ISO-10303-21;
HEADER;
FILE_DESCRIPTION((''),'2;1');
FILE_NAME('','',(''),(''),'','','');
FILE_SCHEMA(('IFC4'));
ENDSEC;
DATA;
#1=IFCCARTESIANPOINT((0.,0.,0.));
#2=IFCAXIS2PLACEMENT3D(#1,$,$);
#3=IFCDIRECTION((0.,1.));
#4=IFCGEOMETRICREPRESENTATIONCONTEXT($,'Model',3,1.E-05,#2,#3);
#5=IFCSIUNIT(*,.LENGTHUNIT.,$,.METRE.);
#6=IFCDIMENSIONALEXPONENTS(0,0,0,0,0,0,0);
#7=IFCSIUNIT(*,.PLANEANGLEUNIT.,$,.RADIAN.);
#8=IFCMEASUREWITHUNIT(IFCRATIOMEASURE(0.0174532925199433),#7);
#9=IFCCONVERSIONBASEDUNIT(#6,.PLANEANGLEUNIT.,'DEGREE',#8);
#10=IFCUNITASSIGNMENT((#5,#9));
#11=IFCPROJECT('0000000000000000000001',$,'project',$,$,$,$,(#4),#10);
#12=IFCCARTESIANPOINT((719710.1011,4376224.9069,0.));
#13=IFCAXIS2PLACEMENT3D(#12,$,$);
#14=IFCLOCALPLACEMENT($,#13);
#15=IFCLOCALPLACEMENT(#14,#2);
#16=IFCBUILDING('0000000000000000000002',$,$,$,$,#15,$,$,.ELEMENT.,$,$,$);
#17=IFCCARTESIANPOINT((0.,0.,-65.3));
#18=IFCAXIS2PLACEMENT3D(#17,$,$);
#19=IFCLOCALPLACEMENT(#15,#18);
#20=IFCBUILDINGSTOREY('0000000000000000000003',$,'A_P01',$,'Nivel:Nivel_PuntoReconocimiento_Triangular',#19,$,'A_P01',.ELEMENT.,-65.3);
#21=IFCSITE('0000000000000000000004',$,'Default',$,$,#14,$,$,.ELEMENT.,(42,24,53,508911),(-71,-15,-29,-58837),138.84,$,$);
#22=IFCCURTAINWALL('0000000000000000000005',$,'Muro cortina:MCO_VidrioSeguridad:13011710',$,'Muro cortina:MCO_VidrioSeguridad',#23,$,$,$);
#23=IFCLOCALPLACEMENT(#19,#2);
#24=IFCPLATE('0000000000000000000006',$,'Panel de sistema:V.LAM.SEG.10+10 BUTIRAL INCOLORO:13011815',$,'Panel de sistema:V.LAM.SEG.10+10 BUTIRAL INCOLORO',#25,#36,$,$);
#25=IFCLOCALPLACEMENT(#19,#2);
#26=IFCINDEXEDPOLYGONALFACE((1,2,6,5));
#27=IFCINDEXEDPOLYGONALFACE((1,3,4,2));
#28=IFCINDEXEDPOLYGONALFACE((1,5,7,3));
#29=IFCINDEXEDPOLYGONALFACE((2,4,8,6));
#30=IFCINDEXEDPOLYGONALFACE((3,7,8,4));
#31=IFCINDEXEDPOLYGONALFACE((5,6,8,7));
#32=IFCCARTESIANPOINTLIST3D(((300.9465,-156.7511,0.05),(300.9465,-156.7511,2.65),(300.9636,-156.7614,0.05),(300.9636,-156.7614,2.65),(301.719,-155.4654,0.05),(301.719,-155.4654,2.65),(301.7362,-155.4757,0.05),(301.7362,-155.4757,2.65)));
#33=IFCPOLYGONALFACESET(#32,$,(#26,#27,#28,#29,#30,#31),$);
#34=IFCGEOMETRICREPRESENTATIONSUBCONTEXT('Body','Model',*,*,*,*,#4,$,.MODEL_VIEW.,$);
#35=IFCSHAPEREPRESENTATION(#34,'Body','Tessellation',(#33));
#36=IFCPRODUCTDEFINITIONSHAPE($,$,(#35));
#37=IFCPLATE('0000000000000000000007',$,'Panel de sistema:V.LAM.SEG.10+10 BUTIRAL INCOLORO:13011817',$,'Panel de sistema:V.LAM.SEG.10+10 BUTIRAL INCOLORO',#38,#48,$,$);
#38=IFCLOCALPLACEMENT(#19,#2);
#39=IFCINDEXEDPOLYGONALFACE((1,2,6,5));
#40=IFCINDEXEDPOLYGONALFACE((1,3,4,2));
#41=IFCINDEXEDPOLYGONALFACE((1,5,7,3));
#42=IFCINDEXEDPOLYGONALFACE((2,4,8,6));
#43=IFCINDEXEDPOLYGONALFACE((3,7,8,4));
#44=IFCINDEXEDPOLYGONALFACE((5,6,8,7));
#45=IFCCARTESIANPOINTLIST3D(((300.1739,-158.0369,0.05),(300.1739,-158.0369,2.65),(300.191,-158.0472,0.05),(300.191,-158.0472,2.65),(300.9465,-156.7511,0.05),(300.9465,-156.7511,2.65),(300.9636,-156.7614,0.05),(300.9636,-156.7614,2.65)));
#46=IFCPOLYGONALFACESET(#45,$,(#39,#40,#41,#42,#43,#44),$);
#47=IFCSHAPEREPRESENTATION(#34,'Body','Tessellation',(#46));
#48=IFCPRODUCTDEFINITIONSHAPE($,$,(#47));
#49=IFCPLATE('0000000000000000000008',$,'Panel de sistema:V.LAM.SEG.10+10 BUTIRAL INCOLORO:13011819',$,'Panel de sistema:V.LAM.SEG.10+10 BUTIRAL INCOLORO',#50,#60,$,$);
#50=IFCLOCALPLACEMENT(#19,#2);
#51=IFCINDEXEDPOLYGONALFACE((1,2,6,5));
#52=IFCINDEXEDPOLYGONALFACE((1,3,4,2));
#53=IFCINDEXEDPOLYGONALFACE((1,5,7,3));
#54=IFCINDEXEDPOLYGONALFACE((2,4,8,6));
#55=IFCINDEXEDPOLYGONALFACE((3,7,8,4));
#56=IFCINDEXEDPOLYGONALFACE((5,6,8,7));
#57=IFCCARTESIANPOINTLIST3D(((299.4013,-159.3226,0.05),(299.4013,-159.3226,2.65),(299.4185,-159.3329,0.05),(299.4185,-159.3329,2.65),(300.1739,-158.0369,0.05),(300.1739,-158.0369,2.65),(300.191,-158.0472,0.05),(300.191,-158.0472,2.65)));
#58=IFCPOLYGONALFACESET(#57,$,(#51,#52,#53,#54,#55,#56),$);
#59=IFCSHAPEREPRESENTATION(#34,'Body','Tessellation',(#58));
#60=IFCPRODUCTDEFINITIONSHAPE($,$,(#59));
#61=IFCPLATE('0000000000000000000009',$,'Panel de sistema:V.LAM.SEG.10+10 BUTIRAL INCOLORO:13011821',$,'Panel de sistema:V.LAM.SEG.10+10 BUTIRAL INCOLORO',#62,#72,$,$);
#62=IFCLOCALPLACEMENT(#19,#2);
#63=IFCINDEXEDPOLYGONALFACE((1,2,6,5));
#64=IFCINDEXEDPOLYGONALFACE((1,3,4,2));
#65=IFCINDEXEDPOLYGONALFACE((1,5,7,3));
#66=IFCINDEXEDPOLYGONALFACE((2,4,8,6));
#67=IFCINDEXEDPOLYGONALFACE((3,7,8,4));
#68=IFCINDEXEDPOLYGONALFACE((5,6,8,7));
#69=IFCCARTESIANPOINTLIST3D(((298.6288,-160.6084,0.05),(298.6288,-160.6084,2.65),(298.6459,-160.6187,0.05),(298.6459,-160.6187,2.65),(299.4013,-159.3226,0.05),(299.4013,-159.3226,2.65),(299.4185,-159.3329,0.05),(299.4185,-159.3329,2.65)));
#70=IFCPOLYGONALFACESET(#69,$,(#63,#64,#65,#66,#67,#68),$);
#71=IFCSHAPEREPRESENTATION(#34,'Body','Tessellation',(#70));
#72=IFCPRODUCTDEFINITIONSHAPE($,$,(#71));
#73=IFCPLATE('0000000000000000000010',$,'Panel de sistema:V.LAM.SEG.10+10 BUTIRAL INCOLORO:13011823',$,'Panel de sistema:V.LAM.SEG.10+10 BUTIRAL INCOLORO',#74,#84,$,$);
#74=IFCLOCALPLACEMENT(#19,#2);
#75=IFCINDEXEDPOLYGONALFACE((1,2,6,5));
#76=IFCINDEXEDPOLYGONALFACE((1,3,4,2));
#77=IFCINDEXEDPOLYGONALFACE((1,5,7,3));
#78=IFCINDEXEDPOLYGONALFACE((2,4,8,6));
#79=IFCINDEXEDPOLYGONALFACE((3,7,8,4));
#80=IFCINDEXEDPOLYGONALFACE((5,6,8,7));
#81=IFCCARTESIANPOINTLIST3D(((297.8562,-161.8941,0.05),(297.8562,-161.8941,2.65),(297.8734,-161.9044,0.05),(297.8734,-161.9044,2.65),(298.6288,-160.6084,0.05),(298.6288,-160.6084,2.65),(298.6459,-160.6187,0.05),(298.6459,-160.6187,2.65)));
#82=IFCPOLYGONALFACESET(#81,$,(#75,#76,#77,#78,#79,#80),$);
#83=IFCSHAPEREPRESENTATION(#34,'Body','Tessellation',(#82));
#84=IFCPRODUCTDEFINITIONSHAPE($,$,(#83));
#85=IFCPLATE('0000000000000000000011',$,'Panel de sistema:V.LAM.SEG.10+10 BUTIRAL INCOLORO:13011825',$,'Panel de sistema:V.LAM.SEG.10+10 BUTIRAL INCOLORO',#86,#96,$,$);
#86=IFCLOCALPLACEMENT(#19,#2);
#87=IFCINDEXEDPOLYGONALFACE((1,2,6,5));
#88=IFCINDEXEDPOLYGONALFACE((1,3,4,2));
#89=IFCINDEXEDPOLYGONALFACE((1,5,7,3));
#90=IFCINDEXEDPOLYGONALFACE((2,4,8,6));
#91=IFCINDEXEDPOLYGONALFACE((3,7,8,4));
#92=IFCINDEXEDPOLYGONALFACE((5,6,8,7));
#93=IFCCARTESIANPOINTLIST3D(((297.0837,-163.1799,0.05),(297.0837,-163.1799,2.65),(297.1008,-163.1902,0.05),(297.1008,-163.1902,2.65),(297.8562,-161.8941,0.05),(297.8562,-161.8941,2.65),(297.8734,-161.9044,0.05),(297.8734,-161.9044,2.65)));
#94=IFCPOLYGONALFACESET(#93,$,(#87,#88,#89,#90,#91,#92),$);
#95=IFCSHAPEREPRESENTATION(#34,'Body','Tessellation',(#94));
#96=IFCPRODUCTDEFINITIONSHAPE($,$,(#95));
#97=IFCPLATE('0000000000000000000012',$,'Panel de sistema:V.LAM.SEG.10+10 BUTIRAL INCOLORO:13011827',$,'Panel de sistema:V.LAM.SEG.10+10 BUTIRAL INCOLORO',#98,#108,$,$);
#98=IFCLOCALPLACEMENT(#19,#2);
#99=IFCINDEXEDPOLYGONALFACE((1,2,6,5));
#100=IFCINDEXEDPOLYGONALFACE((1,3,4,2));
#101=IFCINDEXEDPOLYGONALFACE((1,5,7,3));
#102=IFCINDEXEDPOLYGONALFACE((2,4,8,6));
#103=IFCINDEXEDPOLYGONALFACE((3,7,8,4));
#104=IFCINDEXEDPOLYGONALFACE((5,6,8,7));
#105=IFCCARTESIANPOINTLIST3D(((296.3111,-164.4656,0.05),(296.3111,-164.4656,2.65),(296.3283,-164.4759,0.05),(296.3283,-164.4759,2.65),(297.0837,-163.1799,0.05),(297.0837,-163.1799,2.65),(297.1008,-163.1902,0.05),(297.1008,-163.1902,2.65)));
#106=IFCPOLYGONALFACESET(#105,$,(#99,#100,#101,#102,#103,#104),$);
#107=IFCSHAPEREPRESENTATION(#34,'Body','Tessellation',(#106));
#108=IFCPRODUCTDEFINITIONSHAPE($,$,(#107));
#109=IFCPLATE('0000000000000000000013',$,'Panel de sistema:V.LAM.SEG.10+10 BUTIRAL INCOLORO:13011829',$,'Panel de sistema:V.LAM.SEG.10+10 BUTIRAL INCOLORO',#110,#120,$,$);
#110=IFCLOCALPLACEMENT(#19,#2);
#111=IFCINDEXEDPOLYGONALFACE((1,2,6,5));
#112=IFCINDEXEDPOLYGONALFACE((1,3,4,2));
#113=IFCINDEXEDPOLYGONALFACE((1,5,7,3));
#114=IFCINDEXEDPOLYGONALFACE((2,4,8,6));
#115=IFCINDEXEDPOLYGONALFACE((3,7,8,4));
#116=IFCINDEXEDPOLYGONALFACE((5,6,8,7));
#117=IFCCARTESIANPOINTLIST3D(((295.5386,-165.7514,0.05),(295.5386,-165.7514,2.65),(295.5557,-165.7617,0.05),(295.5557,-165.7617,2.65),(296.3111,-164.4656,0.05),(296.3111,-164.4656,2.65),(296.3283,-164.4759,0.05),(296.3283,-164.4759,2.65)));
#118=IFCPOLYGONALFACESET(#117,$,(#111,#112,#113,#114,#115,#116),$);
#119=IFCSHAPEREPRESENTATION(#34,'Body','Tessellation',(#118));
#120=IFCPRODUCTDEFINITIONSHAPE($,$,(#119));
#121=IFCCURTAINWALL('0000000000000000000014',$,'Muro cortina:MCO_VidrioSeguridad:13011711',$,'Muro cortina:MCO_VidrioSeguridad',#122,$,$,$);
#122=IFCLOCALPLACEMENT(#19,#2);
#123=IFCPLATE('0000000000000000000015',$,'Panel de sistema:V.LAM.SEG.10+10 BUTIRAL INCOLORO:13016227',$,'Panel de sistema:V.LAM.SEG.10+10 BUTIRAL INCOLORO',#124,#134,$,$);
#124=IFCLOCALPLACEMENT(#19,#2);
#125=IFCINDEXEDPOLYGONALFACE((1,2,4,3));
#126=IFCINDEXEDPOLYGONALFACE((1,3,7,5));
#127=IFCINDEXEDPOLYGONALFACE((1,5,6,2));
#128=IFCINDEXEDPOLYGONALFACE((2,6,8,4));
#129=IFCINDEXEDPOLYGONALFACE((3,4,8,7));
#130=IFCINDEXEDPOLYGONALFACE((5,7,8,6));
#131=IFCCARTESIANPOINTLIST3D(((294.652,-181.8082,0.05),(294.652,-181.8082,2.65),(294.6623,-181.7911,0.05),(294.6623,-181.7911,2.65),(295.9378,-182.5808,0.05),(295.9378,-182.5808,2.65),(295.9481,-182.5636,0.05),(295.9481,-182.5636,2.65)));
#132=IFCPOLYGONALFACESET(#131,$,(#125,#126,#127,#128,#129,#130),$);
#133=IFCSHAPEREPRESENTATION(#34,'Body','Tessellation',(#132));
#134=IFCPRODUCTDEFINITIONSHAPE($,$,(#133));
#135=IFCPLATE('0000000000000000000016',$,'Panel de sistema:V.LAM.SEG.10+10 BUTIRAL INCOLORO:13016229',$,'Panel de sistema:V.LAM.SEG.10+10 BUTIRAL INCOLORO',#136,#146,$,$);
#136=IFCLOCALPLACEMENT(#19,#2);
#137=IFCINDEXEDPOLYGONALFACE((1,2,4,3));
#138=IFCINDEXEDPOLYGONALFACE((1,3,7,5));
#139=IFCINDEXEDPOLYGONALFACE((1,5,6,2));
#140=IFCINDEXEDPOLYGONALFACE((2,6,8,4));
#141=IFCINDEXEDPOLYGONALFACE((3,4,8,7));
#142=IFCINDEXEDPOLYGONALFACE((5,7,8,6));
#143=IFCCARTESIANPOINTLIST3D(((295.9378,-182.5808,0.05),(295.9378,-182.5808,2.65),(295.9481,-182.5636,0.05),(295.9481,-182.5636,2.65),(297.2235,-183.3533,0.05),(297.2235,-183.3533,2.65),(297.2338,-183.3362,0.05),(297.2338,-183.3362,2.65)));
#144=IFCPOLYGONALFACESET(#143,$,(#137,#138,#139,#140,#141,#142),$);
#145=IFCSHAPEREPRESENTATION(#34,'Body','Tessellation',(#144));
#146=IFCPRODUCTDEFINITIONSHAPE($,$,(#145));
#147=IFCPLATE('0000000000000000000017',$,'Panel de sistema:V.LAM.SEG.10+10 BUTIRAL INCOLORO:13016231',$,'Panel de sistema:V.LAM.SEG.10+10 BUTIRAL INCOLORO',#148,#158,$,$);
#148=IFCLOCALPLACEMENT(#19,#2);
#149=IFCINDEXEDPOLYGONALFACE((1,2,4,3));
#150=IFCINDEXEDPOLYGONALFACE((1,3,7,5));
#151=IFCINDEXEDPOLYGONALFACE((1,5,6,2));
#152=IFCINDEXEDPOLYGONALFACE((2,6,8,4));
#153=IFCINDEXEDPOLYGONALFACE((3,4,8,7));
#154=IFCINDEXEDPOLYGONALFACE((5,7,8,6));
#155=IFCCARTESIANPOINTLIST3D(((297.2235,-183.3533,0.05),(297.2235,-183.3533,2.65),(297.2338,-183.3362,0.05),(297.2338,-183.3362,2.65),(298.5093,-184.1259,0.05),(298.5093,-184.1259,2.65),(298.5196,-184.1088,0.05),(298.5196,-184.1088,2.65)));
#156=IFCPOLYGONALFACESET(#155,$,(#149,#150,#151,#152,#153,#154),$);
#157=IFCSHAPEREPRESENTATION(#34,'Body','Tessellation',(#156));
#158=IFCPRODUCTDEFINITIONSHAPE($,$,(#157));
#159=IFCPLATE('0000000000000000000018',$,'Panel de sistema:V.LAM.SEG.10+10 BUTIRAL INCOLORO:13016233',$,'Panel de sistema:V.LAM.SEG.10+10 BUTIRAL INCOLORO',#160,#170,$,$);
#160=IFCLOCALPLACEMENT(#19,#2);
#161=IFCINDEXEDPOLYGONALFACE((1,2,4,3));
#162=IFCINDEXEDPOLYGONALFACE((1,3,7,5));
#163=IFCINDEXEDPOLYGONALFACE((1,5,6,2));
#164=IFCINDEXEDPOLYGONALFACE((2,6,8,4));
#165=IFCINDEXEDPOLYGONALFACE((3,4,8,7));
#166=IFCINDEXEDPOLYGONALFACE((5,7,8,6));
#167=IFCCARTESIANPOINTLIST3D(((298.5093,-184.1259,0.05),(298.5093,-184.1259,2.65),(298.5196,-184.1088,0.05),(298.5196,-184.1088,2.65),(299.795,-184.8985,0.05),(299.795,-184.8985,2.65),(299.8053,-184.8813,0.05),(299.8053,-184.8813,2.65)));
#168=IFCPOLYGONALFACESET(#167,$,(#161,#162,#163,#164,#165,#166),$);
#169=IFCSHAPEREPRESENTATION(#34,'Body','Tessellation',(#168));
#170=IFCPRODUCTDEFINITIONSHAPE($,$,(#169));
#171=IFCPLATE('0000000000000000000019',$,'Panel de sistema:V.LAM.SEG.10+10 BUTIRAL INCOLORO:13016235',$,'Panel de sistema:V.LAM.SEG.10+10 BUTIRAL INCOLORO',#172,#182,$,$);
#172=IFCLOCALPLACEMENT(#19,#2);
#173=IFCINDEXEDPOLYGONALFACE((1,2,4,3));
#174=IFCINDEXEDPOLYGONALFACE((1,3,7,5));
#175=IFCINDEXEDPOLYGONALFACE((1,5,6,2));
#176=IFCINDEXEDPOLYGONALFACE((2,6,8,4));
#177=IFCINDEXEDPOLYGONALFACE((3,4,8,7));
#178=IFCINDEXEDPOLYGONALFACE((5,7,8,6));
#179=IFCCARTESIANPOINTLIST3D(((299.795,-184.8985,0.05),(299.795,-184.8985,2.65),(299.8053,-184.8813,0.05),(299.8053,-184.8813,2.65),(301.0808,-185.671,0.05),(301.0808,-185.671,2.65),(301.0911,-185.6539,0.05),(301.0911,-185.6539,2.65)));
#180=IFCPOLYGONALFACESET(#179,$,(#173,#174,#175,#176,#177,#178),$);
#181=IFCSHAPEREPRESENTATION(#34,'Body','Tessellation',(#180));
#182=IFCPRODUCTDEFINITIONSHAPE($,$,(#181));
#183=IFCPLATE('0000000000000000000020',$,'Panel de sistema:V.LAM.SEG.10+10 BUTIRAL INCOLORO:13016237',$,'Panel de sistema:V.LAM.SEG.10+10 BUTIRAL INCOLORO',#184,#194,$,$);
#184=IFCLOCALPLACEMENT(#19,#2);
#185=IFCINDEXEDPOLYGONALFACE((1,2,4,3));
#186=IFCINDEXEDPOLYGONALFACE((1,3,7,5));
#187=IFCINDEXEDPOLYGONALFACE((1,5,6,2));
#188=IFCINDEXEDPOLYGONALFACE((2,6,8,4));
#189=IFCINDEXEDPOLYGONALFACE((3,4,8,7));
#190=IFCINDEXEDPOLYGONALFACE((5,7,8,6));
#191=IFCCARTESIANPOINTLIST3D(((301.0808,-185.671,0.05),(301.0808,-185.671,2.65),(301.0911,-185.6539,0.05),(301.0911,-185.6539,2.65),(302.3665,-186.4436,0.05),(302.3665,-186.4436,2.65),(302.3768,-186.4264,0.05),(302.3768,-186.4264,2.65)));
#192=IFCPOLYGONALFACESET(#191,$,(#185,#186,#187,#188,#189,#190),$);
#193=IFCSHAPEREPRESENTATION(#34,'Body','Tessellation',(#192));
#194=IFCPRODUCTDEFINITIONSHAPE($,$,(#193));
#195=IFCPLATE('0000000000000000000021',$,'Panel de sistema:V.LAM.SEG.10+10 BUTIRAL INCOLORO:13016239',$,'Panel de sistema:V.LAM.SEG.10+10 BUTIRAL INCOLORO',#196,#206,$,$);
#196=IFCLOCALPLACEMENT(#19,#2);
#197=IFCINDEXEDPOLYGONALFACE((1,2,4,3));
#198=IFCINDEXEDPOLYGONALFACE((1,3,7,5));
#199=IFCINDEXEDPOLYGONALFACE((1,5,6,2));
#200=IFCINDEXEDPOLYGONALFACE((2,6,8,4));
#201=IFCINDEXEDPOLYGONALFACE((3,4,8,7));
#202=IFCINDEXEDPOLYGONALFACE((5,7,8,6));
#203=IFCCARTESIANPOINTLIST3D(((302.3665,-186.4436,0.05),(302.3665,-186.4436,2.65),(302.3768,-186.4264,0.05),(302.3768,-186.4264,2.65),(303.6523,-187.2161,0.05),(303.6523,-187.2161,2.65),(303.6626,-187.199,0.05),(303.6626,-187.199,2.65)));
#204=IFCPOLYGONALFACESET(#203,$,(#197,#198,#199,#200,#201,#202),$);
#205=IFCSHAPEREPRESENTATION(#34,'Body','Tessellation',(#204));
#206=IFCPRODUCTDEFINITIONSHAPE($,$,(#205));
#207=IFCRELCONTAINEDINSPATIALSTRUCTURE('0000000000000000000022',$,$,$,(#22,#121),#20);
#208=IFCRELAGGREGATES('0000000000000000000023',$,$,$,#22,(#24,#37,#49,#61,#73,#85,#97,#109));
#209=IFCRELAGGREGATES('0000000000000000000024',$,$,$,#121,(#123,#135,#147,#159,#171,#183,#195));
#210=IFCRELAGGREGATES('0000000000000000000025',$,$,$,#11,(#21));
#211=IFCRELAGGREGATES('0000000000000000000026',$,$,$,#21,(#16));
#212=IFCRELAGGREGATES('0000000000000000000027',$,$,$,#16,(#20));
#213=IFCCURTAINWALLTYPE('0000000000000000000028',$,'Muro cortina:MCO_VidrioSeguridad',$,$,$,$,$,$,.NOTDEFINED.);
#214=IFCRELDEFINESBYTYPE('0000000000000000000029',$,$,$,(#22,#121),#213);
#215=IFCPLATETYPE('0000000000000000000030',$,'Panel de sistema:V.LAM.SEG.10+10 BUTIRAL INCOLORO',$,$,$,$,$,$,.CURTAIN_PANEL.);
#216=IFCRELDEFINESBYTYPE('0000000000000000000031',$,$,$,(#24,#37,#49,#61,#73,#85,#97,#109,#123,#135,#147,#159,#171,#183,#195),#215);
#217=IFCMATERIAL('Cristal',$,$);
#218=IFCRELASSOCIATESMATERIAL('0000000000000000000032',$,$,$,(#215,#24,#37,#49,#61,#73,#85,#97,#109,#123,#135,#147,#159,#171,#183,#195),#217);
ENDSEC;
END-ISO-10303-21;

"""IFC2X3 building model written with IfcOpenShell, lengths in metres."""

from ifc_helpers import new_model, entity, si_unit, converted_unit, direction, frame, origin, origin_2d_with_axis, place, context, subcontext, project, spatial, rectangle, extrude, source, transform, mapped, material, type_object, type_shapes, element, aggregate, save


model = new_model("IFC2X3")

# Units and contexts
model_context = context("Model", 3, precision=1e-05, world=origin(), true_north=direction((0.0, 1.0)))
body_context = subcontext(model_context, "Body", "Model", "MODEL_VIEW")
ifc_project = project(units=[si_unit("LENGTHUNIT", "METRE"), converted_unit("PLANEANGLEUNIT", "DEGREE", entity("IfcRatioMeasure", 0.0174532925199433), si_unit("PLANEANGLEUNIT", "RADIAN"), dimensions=[0, 0, 0, 0, 0, 0, 0])], contexts=[model_context])

# Site, building, storey
site_placement = place(None, frame((719710.1011, 4376224.9069, 0.0)))
site = spatial("IfcSite", under=ifc_project, at=site_placement, Name="Default", CompositionType="ELEMENT", RefLatitude=(42, 24, 53, 508911), RefLongitude=(-71, -15, -29, -58837), RefElevation=138.84)
building_placement = place(site_placement, origin())
building = spatial("IfcBuilding", under=site, at=building_placement, CompositionType="ELEMENT")
storey_placement = place(building_placement, frame((0.0, 0.0, -65.3)))
storey = spatial("IfcBuildingStorey", under=building, at=storey_placement, Name="A_P01", ObjectType="Nivel:Nivel_PuntoReconocimiento_Triangular", LongName="A_P01", CompositionType="ELEMENT", Elevation=-65.3)

# Curtain walls, plates
curtain_wall_type = type_object("IfcCurtainWallType", Name="Muro cortina:MCO_VidrioSeguridad", PredefinedType="NOTDEFINED")
curtain_wall_1_placement = place(storey_placement, frame((0.0, 0.0, 65.3)))
curtain_wall_1 = element("IfcCurtainWall", 1, at=curtain_wall_1_placement, inside=storey, type_object=curtain_wall_type, Name="Muro cortina:MCO_VidrioSeguridad:13011710", ObjectType="Muro cortina:MCO_VidrioSeguridad")
ifc_material_1 = material(Name="Cristal")
plate_type_1 = type_object("IfcPlateType", Name="Panel de sistema:V.LAM.SEG.10+10 BUTIRAL INCOLORO", PredefinedType="CURTAIN_PANEL", material=ifc_material_1)
shared_shape_1 = source(origin(), body_context, "Body", "SweptSolid", [
    extrude(rectangle(XDim=0.02, YDim=1.5, at=origin_2d_with_axis()), frame((0.0, 0.0, 0.0), z_axis=(0.0, 0.0, 1.0), x_axis=(0.0, 1.0, 0.0)), (0.0, 0.0, 1.0), 2.6),
])
type_shapes(plate_type_1, [shared_shape_1])
plate_1_placement = place(curtain_wall_1_placement, frame((301.3413, -156.1134, -65.25), z_axis=(0.0, 0.0, 1.0), x_axis=(-0.515038, -0.857167, 0.0)))
plate_1 = element("IfcPlate", 2, at=plate_1_placement, type_object=plate_type_1, material=ifc_material_1, Name="Panel de sistema:V.LAM.SEG.10+10 BUTIRAL INCOLORO:13011815", ObjectType="Panel de sistema:V.LAM.SEG.10+10 BUTIRAL INCOLORO", context=body_context, shape_type="MappedRepresentation", body=[
    mapped(shared_shape_1, transform((0.0, 0.0, 0.0), scale=1.0)),
])
plate_2_placement = place(curtain_wall_1_placement, frame((300.5687, -157.3991, -65.25), z_axis=(0.0, 0.0, 1.0), x_axis=(-0.515038, -0.857167, 0.0)))
plate_2 = element("IfcPlate", 3, at=plate_2_placement, type_object=plate_type_1, material=ifc_material_1, Name="Panel de sistema:V.LAM.SEG.10+10 BUTIRAL INCOLORO:13011817", ObjectType="Panel de sistema:V.LAM.SEG.10+10 BUTIRAL INCOLORO", context=body_context, shape_type="MappedRepresentation", body=[
    mapped(shared_shape_1, transform((0.0, 0.0, 0.0), scale=1.0)),
])
plate_3_placement = place(curtain_wall_1_placement, frame((299.7962, -158.6849, -65.25), z_axis=(0.0, 0.0, 1.0), x_axis=(-0.515038, -0.857167, 0.0)))
plate_3 = element("IfcPlate", 4, at=plate_3_placement, type_object=plate_type_1, material=ifc_material_1, Name="Panel de sistema:V.LAM.SEG.10+10 BUTIRAL INCOLORO:13011819", ObjectType="Panel de sistema:V.LAM.SEG.10+10 BUTIRAL INCOLORO", context=body_context, shape_type="MappedRepresentation", body=[
    mapped(shared_shape_1, transform((0.0, 0.0, 0.0), scale=1.0)),
])
plate_4_placement = place(curtain_wall_1_placement, frame((299.0236, -159.9706, -65.25), z_axis=(0.0, 0.0, 1.0), x_axis=(-0.515038, -0.857167, 0.0)))
plate_4 = element("IfcPlate", 5, at=plate_4_placement, type_object=plate_type_1, material=ifc_material_1, Name="Panel de sistema:V.LAM.SEG.10+10 BUTIRAL INCOLORO:13011821", ObjectType="Panel de sistema:V.LAM.SEG.10+10 BUTIRAL INCOLORO", context=body_context, shape_type="MappedRepresentation", body=[
    mapped(shared_shape_1, transform((0.0, 0.0, 0.0), scale=1.0)),
])
plate_5_placement = place(curtain_wall_1_placement, frame((298.2511, -161.2564, -65.25), z_axis=(0.0, 0.0, 1.0), x_axis=(-0.515038, -0.857167, 0.0)))
plate_5 = element("IfcPlate", 6, at=plate_5_placement, type_object=plate_type_1, material=ifc_material_1, Name="Panel de sistema:V.LAM.SEG.10+10 BUTIRAL INCOLORO:13011823", ObjectType="Panel de sistema:V.LAM.SEG.10+10 BUTIRAL INCOLORO", context=body_context, shape_type="MappedRepresentation", body=[
    mapped(shared_shape_1, transform((0.0, 0.0, 0.0), scale=1.0)),
])
plate_6_placement = place(curtain_wall_1_placement, frame((297.4785, -162.5421, -65.25), z_axis=(0.0, 0.0, 1.0), x_axis=(-0.515038, -0.857167, 0.0)))
plate_6 = element("IfcPlate", 7, at=plate_6_placement, type_object=plate_type_1, material=ifc_material_1, Name="Panel de sistema:V.LAM.SEG.10+10 BUTIRAL INCOLORO:13011825", ObjectType="Panel de sistema:V.LAM.SEG.10+10 BUTIRAL INCOLORO", context=body_context, shape_type="MappedRepresentation", body=[
    mapped(shared_shape_1, transform((0.0, 0.0, 0.0), scale=1.0)),
])
plate_7_placement = place(curtain_wall_1_placement, frame((296.706, -163.8279, -65.25), z_axis=(0.0, 0.0, 1.0), x_axis=(-0.515038, -0.857167, 0.0)))
plate_7 = element("IfcPlate", 8, at=plate_7_placement, type_object=plate_type_1, material=ifc_material_1, Name="Panel de sistema:V.LAM.SEG.10+10 BUTIRAL INCOLORO:13011827", ObjectType="Panel de sistema:V.LAM.SEG.10+10 BUTIRAL INCOLORO", context=body_context, shape_type="MappedRepresentation", body=[
    mapped(shared_shape_1, transform((0.0, 0.0, 0.0), scale=1.0)),
])
plate_8_placement = place(curtain_wall_1_placement, frame((295.9334, -165.1136, -65.25), z_axis=(0.0, 0.0, 1.0), x_axis=(-0.515038, -0.857167, 0.0)))
plate_8 = element("IfcPlate", 9, at=plate_8_placement, type_object=plate_type_1, material=ifc_material_1, Name="Panel de sistema:V.LAM.SEG.10+10 BUTIRAL INCOLORO:13011829", ObjectType="Panel de sistema:V.LAM.SEG.10+10 BUTIRAL INCOLORO", context=body_context, shape_type="MappedRepresentation", body=[
    mapped(shared_shape_1, transform((0.0, 0.0, 0.0), scale=1.0)),
])
curtain_wall_2_placement = place(storey_placement, frame((0.0, 0.0, 65.3)))
curtain_wall_2 = element("IfcCurtainWall", 10, at=curtain_wall_2_placement, inside=storey, type_object=curtain_wall_type, Name="Muro cortina:MCO_VidrioSeguridad:13011711", ObjectType="Muro cortina:MCO_VidrioSeguridad")
plate_9_placement = place(curtain_wall_2_placement, frame((295.3001, -182.1859, -65.25), z_axis=(0.0, 0.0, 1.0), x_axis=(0.857167, -0.515038, 0.0)))
plate_9 = element("IfcPlate", 11, at=plate_9_placement, type_object=plate_type_1, material=ifc_material_1, Name="Panel de sistema:V.LAM.SEG.10+10 BUTIRAL INCOLORO:13016227", ObjectType="Panel de sistema:V.LAM.SEG.10+10 BUTIRAL INCOLORO", context=body_context, shape_type="MappedRepresentation", body=[
    mapped(shared_shape_1, transform((0.0, 0.0, 0.0), scale=1.0)),
])
plate_10_placement = place(curtain_wall_2_placement, frame((296.5858, -182.9585, -65.25), z_axis=(0.0, 0.0, 1.0), x_axis=(0.857167, -0.515038, 0.0)))
plate_10 = element("IfcPlate", 12, at=plate_10_placement, type_object=plate_type_1, material=ifc_material_1, Name="Panel de sistema:V.LAM.SEG.10+10 BUTIRAL INCOLORO:13016229", ObjectType="Panel de sistema:V.LAM.SEG.10+10 BUTIRAL INCOLORO", context=body_context, shape_type="MappedRepresentation", body=[
    mapped(shared_shape_1, transform((0.0, 0.0, 0.0), scale=1.0)),
])
plate_11_placement = place(curtain_wall_2_placement, frame((297.8716, -183.731, -65.25), z_axis=(0.0, 0.0, 1.0), x_axis=(0.857167, -0.515038, 0.0)))
plate_11 = element("IfcPlate", 13, at=plate_11_placement, type_object=plate_type_1, material=ifc_material_1, Name="Panel de sistema:V.LAM.SEG.10+10 BUTIRAL INCOLORO:13016231", ObjectType="Panel de sistema:V.LAM.SEG.10+10 BUTIRAL INCOLORO", context=body_context, shape_type="MappedRepresentation", body=[
    mapped(shared_shape_1, transform((0.0, 0.0, 0.0), scale=1.0)),
])
plate_12_placement = place(curtain_wall_2_placement, frame((299.1573, -184.5036, -65.25), z_axis=(0.0, 0.0, 1.0), x_axis=(0.857167, -0.515038, 0.0)))
plate_12 = element("IfcPlate", 14, at=plate_12_placement, type_object=plate_type_1, material=ifc_material_1, Name="Panel de sistema:V.LAM.SEG.10+10 BUTIRAL INCOLORO:13016233", ObjectType="Panel de sistema:V.LAM.SEG.10+10 BUTIRAL INCOLORO", context=body_context, shape_type="MappedRepresentation", body=[
    mapped(shared_shape_1, transform((0.0, 0.0, 0.0), scale=1.0)),
])
plate_13_placement = place(curtain_wall_2_placement, frame((300.4431, -185.2762, -65.25), z_axis=(0.0, 0.0, 1.0), x_axis=(0.857167, -0.515038, 0.0)))
plate_13 = element("IfcPlate", 15, at=plate_13_placement, type_object=plate_type_1, material=ifc_material_1, Name="Panel de sistema:V.LAM.SEG.10+10 BUTIRAL INCOLORO:13016235", ObjectType="Panel de sistema:V.LAM.SEG.10+10 BUTIRAL INCOLORO", context=body_context, shape_type="MappedRepresentation", body=[
    mapped(shared_shape_1, transform((0.0, 0.0, 0.0), scale=1.0)),
])
plate_14_placement = place(curtain_wall_2_placement, frame((301.7288, -186.0487, -65.25), z_axis=(0.0, 0.0, 1.0), x_axis=(0.857167, -0.515038, 0.0)))
plate_14 = element("IfcPlate", 16, at=plate_14_placement, type_object=plate_type_1, material=ifc_material_1, Name="Panel de sistema:V.LAM.SEG.10+10 BUTIRAL INCOLORO:13016237", ObjectType="Panel de sistema:V.LAM.SEG.10+10 BUTIRAL INCOLORO", context=body_context, shape_type="MappedRepresentation", body=[
    mapped(shared_shape_1, transform((0.0, 0.0, 0.0), scale=1.0)),
])
plate_15_placement = place(curtain_wall_2_placement, frame((303.0146, -186.8213, -65.25), z_axis=(0.0, 0.0, 1.0), x_axis=(0.857167, -0.515038, 0.0)))
plate_15 = element("IfcPlate", 17, at=plate_15_placement, type_object=plate_type_1, material=ifc_material_1, Name="Panel de sistema:V.LAM.SEG.10+10 BUTIRAL INCOLORO:13016239", ObjectType="Panel de sistema:V.LAM.SEG.10+10 BUTIRAL INCOLORO", context=body_context, shape_type="MappedRepresentation", body=[
    mapped(shared_shape_1, transform((0.0, 0.0, 0.0), scale=1.0)),
])

aggregate(curtain_wall_1, [plate_1, plate_2, plate_3, plate_4, plate_5, plate_6, plate_7, plate_8])
aggregate(curtain_wall_2, [plate_9, plate_10, plate_11, plate_12, plate_13, plate_14, plate_15])

save(model, "model.ifc")
